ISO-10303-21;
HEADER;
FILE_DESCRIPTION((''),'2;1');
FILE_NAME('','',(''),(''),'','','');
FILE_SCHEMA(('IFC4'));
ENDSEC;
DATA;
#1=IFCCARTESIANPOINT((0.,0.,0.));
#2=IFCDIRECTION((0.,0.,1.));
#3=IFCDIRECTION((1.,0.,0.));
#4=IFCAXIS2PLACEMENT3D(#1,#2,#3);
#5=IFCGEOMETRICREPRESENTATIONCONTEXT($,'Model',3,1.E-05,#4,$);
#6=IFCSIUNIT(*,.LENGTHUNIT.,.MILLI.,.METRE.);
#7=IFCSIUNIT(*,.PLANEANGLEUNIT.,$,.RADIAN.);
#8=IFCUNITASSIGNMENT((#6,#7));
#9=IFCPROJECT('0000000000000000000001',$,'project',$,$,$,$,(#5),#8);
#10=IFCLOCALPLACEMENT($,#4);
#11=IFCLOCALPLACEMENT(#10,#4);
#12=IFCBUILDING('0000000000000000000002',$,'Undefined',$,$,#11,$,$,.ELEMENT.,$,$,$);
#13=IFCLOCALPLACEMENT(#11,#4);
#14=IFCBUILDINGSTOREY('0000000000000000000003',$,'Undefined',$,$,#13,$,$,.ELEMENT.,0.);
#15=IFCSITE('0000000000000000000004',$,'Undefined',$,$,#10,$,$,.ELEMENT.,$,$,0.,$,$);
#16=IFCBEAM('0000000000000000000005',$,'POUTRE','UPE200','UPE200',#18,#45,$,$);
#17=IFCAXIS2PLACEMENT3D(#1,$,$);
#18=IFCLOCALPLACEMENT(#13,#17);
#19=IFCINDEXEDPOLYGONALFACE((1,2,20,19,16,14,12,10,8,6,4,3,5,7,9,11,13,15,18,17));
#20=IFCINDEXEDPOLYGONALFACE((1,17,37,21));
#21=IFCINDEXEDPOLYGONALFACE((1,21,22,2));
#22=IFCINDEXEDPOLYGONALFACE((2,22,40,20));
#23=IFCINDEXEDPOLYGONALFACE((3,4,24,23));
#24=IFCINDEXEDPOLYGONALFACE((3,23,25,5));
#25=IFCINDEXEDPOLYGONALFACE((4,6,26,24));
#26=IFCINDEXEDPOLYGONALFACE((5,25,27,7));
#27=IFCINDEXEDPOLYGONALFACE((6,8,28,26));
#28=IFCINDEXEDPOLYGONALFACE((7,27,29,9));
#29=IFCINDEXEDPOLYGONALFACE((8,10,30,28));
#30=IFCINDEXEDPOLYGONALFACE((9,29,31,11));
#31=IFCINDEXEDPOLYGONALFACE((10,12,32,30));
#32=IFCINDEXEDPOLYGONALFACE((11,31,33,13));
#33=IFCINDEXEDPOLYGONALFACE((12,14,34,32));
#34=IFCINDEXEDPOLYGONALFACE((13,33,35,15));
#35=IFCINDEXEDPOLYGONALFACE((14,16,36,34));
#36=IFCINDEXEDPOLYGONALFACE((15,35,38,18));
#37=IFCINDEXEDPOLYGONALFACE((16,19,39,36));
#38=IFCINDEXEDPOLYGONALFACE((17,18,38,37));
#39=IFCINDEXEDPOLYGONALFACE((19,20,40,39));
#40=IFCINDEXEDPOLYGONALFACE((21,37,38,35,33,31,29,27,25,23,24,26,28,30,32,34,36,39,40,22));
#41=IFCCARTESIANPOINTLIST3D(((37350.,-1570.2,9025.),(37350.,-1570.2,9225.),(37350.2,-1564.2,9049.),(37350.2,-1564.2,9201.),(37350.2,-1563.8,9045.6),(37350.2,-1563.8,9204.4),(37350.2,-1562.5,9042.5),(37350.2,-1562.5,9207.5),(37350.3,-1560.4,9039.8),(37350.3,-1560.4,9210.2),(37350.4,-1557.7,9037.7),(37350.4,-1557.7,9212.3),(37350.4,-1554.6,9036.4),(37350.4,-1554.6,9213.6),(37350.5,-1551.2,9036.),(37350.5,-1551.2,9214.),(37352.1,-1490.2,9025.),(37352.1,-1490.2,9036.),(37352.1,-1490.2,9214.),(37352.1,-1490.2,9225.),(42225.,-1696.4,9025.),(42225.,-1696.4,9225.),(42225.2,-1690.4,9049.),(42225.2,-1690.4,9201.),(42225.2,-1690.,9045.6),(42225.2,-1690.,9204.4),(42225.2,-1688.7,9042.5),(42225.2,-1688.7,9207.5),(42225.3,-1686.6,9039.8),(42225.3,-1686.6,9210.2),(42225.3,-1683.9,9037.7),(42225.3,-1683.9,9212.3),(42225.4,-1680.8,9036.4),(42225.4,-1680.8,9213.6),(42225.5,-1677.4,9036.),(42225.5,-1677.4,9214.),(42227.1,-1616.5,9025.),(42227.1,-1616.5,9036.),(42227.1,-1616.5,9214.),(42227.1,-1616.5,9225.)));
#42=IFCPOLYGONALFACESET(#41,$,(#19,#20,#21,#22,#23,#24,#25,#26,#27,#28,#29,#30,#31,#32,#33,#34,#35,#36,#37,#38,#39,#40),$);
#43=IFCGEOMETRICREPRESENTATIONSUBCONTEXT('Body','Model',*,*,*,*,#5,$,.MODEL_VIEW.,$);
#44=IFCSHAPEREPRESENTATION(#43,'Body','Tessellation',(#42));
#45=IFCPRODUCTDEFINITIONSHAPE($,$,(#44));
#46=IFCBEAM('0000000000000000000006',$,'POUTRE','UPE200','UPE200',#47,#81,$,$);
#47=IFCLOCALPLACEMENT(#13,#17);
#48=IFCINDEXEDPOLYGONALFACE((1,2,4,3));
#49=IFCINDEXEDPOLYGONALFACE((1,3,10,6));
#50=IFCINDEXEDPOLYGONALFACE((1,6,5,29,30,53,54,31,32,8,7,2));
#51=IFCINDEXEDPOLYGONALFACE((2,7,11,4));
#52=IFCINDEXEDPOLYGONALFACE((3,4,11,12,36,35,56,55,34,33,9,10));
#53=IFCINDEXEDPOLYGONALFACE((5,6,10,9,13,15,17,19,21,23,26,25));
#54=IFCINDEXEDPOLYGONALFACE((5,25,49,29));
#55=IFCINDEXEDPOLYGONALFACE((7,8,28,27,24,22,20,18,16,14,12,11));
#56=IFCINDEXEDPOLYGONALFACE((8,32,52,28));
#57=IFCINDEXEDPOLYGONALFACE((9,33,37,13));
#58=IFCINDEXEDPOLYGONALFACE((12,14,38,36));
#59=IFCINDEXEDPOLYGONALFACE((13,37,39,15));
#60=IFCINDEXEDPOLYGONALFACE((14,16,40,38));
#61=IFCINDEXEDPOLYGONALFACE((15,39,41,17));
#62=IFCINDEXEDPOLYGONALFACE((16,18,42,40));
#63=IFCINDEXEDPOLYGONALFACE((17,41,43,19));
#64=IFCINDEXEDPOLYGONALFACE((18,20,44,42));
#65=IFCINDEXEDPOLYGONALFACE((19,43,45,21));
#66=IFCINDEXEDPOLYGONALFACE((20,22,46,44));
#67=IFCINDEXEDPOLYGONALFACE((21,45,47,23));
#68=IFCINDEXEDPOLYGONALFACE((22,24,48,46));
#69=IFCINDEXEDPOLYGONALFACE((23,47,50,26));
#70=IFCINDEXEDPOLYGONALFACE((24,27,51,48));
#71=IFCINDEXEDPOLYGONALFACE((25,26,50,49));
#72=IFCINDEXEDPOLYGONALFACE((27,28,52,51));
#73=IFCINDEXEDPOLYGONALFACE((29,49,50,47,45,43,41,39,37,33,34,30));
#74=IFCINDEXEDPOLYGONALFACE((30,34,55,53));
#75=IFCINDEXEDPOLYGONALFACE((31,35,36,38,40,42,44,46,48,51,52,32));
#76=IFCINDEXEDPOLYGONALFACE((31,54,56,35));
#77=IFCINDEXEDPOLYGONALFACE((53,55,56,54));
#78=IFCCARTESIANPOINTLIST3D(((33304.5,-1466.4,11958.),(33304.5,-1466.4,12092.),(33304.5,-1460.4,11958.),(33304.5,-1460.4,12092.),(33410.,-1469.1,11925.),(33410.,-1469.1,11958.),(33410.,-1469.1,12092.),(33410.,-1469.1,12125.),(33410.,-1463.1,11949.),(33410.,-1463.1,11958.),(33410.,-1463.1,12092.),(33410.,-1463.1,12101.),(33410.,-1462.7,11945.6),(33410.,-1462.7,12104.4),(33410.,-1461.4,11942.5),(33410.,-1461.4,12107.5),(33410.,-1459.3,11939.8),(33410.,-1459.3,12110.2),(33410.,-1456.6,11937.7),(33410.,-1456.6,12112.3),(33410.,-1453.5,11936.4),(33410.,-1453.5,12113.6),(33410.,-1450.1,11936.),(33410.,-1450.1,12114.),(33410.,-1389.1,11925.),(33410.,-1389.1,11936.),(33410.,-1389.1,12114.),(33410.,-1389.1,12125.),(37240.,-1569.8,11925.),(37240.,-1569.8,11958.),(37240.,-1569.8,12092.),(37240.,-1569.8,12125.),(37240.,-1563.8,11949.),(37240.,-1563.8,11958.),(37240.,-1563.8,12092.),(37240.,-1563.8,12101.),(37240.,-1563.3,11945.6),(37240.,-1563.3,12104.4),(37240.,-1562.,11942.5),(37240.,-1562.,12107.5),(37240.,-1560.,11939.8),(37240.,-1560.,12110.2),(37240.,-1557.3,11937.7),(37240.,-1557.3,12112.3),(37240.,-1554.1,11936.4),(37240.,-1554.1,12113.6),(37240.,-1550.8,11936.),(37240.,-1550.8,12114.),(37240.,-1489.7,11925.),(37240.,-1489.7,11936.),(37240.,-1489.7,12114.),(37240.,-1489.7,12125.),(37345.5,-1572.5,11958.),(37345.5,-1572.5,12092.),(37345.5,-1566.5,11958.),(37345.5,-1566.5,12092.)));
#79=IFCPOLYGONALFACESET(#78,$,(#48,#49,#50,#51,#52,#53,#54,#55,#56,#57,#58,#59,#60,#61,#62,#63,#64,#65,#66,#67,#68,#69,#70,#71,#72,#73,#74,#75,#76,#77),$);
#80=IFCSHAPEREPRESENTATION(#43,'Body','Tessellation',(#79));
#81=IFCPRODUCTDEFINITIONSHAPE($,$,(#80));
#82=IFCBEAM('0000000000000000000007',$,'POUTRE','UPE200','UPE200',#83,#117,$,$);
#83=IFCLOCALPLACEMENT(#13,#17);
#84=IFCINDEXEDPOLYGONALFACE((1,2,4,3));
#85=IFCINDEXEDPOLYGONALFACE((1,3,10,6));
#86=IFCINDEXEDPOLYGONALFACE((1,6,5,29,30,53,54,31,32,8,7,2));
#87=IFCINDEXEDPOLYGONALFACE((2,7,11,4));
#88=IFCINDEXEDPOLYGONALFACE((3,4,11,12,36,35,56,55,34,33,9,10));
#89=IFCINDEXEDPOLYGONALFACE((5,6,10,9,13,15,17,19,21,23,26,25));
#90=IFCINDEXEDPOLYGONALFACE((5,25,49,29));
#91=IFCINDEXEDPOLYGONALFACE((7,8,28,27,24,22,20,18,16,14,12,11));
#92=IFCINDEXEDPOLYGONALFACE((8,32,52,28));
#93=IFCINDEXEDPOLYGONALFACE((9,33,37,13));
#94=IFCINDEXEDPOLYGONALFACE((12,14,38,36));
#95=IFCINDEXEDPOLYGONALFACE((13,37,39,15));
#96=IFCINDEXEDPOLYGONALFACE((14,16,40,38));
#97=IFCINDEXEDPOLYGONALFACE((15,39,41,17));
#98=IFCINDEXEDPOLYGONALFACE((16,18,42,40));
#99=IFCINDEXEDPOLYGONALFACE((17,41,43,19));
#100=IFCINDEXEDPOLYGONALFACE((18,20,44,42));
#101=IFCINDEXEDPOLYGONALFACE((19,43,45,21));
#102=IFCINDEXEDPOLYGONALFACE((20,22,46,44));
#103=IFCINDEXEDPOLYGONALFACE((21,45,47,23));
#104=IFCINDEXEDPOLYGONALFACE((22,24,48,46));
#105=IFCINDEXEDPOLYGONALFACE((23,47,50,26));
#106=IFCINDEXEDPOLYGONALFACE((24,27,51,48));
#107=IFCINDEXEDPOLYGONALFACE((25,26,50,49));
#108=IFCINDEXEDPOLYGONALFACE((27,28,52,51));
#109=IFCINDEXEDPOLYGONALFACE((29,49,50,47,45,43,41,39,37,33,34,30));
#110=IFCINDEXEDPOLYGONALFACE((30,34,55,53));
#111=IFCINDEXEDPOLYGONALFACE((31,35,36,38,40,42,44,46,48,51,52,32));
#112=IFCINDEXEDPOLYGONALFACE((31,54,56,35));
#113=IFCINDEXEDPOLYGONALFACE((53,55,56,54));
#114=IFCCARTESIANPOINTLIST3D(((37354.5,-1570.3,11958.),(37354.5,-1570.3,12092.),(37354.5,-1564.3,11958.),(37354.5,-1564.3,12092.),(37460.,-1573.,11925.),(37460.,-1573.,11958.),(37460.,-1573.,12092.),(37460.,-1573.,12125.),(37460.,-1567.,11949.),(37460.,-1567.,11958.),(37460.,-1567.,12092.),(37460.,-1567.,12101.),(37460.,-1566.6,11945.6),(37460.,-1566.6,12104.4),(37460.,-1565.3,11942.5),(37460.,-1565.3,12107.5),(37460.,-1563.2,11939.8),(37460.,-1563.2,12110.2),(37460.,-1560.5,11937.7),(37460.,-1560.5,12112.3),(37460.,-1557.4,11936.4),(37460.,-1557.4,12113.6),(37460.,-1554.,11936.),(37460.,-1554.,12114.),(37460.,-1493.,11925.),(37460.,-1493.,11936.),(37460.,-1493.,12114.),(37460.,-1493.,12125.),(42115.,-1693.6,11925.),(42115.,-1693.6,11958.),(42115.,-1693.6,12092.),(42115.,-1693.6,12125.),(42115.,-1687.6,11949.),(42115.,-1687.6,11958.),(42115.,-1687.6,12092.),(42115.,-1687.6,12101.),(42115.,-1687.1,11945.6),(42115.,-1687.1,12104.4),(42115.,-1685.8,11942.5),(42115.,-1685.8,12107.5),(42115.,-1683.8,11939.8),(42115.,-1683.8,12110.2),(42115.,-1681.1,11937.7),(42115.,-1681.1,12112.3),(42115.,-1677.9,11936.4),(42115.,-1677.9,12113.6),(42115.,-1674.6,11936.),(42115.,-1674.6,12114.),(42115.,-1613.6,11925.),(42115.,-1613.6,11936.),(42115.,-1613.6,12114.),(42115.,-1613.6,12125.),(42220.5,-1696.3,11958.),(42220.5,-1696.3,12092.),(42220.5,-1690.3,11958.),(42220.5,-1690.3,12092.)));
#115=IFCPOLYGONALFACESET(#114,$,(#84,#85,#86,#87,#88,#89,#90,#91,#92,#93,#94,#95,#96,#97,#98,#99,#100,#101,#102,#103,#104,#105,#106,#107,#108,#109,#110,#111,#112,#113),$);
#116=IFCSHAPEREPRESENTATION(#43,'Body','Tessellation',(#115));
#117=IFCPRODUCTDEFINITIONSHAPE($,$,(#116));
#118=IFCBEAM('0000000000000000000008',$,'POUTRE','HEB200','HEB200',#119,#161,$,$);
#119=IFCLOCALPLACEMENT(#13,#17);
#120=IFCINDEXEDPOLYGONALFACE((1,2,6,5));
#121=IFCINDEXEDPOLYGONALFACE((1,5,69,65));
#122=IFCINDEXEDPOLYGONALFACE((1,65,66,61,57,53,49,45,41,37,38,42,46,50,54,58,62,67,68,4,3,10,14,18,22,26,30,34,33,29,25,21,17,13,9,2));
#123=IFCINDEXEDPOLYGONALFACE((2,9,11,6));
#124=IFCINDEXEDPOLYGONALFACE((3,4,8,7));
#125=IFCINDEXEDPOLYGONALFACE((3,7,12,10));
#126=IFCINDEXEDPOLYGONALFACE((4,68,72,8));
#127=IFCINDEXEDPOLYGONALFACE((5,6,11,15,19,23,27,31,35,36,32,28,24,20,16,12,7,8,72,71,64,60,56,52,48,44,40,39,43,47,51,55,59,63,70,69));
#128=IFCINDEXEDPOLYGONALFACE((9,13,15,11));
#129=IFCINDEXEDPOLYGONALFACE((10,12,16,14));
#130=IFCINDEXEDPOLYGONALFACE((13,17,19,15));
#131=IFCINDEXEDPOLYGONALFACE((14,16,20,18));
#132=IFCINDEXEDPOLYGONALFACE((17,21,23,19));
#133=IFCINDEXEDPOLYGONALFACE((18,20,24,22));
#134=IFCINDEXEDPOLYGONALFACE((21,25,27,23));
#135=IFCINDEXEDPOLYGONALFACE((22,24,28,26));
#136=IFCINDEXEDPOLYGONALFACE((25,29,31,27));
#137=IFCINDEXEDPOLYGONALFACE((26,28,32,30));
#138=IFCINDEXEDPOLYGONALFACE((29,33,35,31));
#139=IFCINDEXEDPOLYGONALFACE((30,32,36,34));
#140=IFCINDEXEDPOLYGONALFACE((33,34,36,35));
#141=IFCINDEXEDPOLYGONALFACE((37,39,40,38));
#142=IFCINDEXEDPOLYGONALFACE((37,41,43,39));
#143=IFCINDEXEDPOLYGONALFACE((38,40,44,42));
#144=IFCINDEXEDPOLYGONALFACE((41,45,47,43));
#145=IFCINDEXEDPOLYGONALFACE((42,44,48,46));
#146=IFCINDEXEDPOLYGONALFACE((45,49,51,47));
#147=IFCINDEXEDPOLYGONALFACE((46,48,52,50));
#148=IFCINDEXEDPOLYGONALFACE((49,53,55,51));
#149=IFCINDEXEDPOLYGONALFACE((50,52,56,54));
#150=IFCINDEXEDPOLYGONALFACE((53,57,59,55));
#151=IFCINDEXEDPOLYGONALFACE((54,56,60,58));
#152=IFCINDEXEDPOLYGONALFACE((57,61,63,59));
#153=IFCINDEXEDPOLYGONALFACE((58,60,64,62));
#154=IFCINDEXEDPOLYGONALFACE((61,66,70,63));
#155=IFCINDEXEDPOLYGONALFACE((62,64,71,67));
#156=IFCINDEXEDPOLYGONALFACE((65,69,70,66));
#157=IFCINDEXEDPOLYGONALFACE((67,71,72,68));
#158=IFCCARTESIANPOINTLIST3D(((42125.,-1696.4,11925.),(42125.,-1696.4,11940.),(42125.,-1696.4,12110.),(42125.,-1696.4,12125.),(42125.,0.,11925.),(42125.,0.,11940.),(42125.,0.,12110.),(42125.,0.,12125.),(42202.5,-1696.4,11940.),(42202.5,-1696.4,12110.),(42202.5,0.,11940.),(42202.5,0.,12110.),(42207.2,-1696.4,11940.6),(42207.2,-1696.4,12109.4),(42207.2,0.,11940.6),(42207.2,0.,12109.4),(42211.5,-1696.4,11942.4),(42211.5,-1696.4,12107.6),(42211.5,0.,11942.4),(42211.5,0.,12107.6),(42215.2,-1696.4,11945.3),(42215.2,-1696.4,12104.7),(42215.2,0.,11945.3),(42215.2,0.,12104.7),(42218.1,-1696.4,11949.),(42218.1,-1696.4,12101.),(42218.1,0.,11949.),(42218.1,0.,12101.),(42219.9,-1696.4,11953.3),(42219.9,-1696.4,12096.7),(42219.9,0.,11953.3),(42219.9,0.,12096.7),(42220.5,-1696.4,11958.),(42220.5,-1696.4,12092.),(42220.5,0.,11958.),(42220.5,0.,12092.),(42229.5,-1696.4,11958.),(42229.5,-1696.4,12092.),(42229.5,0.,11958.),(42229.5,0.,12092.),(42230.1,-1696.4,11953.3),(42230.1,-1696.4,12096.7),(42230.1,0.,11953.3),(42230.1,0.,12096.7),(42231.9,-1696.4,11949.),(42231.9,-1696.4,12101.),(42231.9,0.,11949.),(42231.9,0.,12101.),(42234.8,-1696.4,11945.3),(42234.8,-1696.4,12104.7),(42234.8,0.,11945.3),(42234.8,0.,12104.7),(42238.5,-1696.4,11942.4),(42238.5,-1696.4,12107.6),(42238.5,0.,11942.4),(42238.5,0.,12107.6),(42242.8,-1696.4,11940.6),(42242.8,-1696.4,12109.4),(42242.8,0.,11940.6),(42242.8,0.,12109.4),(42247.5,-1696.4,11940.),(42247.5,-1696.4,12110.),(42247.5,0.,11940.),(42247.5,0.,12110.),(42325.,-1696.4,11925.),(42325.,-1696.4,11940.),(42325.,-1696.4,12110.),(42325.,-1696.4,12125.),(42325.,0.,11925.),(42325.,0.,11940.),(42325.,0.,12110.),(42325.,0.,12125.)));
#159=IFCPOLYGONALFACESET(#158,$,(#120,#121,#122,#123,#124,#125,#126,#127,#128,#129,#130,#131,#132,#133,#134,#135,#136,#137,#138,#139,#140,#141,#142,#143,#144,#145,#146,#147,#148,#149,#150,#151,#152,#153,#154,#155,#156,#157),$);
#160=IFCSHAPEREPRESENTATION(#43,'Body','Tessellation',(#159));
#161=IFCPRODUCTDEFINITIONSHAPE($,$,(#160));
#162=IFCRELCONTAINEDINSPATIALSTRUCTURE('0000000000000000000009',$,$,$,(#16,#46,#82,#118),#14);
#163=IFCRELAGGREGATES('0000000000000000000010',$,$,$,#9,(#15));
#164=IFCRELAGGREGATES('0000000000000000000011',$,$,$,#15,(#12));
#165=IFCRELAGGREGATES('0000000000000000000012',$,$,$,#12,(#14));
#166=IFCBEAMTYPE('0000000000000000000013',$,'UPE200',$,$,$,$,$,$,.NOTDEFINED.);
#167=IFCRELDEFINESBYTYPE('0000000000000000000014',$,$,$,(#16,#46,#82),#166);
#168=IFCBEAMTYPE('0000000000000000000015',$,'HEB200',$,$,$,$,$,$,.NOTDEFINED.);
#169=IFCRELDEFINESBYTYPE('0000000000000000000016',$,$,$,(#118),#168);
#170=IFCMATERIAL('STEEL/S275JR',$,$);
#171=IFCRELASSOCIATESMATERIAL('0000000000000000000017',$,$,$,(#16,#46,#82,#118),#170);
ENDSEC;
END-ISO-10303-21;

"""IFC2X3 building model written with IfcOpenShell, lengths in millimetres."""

from ifc_helpers import new_model, si_unit, frame, origin_with_axes, origin_2d_with_axis, place, context, subcontext, project, spatial, rectangle, i_section, u_section, extrude, boolean, halfspace, material, type_object, element, save


model = new_model("IFC2X3")

# Units and contexts
model_context = context("Model", 3, precision=1e-05, world=origin_with_axes())
body_context = subcontext(model_context, "Body", "Model", "MODEL_VIEW")
ifc_project = project(units=[si_unit("LENGTHUNIT", "METRE", prefix="MILLI"), si_unit("PLANEANGLEUNIT", "RADIAN")], contexts=[model_context])

# Site, building, storey
site_placement = place(None, origin_with_axes())
site = spatial("IfcSite", under=ifc_project, at=site_placement, Name="Undefined", CompositionType="ELEMENT", RefElevation=0.0)
building_placement = place(site_placement, origin_with_axes())
building = spatial("IfcBuilding", under=site, at=building_placement, Name="Undefined", CompositionType="ELEMENT")
storey_placement = place(building_placement, origin_with_axes())
storey = spatial("IfcBuildingStorey", under=building, at=storey_placement, Name="Undefined", CompositionType="ELEMENT", Elevation=0.0)

# Shared definitions
ifc_material_1 = material(Name="STEEL/S275JR")

# Beams
beam_type_1 = type_object("IfcBeamType", Name="UPE200", PredefinedType="NOTDEFINED")
for number, where, z_axis, x_axis, name in (
    (1, (37351.0, -1530.2, 9125.0), (0.0, 0.0, -1.0), (0.999665, -0.025886, 0.0), "POUTRE"),
):
    element("IfcBeam", number, at=place(storey_placement, frame(where, z_axis=z_axis, x_axis=x_axis)), inside=storey, type_object=beam_type_1, material=ifc_material_1, Name=name, Description="UPE200", ObjectType="UPE200", context=body_context, shape_type="SweptSolid", body=[
        extrude(u_section(Depth=200.0, FlangeWidth=80.0, WebThickness=6.0, FlangeThickness=11.0, FilletRadius=13.0, at=origin_2d_with_axis()), frame((4876.6, 0.0, 0.0), z_axis=(-1.0, 0.0, 0.0), x_axis=(0.0, -1.0, 0.0)), (0.0, 0.0, 1.0), 4876.6),
    ])
beam_1_placement = place(storey_placement, frame((33301.1, -1426.3, 12025.0), z_axis=(0.0, 0.0, -1.0), x_axis=(0.999655, -0.026267, 0.0)))
element("IfcBeam", 2, at=beam_1_placement, inside=storey, type_object=beam_type_1, material=ifc_material_1, Name="POUTRE", Description="UPE200", ObjectType="UPE200", context=body_context, shape_type="CSG", body=[
    boolean("DIFFERENCE", boolean("DIFFERENCE", boolean("DIFFERENCE", boolean("DIFFERENCE", boolean("DIFFERENCE", boolean("DIFFERENCE", extrude(u_section(Depth=200.0, FlangeWidth=80.0, WebThickness=6.0, FlangeThickness=11.0, FilletRadius=13.0, at=origin_2d_with_axis()), frame((4047.9, 0.0, 0.0), z_axis=(-1.0, 0.0, 0.0), x_axis=(0.0, -1.0, 0.0)), (0.0, 0.0, 1.0), 4046.5), extrude(rectangle(XDim=34.0, YDim=107.5, at=origin_2d_with_axis()), frame((3990.3, -143.0, 84.0), z_axis=(0.026267, 0.999655, 0.0), x_axis=(0.0, 0.0, 1.0)), (0.0, 0.0, 1.0), 185.4)), extrude(rectangle(XDim=34.0, YDim=107.5, at=origin_2d_with_axis()), frame((3990.3, -143.0, -84.0), z_axis=(0.026267, 0.999655, 0.0), x_axis=(0.0, 0.0, 1.0)), (0.0, 0.0, 1.0), 185.4)), extrude(rectangle(XDim=34.0, YDim=107.5, at=origin_2d_with_axis()), frame((59.0, 145.8, 84.0), z_axis=(-0.026267, -0.999655, 0.0), x_axis=(0.0, 0.0, 1.0)), (0.0, 0.0, 1.0), 188.2)), extrude(rectangle(XDim=34.0, YDim=107.5, at=origin_2d_with_axis()), frame((59.0, 145.8, -84.0), z_axis=(-0.026267, -0.999655, 0.0), x_axis=(0.0, 0.0, 1.0)), (0.0, 0.0, 1.0), 188.2)), halfspace(frame((4045.8, 0.0, 1000.0), z_axis=(-0.999655, 0.026267, 0.0), x_axis=(-0.026267, -0.999655, 0.0)), True)), halfspace(frame((3.5, 0.0, 1000.0), z_axis=(0.999655, -0.026267, 0.0), x_axis=(0.026267, 0.999655, 0.0)), True)),
])
beam_2_placement = place(storey_placement, frame((37351.0, -1530.2, 12025.0), z_axis=(0.0, 0.0, -1.0), x_axis=(0.999665, -0.025886, 0.0)))
element("IfcBeam", 3, at=beam_2_placement, inside=storey, type_object=beam_type_1, material=ifc_material_1, Name="POUTRE", Description="UPE200", ObjectType="UPE200", context=body_context, shape_type="CSG", body=[
    boolean("DIFFERENCE", boolean("DIFFERENCE", boolean("DIFFERENCE", boolean("DIFFERENCE", boolean("DIFFERENCE", boolean("DIFFERENCE", extrude(u_section(Depth=200.0, FlangeWidth=80.0, WebThickness=6.0, FlangeThickness=11.0, FilletRadius=13.0, at=origin_2d_with_axis()), frame((4873.1, 0.0, 0.0), z_axis=(-1.0, 0.0, 0.0), x_axis=(0.0, -1.0, 0.0)), (0.0, 0.0, 1.0), 4871.7), extrude(rectangle(XDim=34.0, YDim=107.5, at=origin_2d_with_axis()), frame((4815.1, -162.9, 84.0), z_axis=(0.025886, 0.999665, 0.0), x_axis=(0.0, 0.0, 1.0)), (0.0, 0.0, 1.0), 205.3)), extrude(rectangle(XDim=34.0, YDim=107.5, at=origin_2d_with_axis()), frame((4815.1, -162.9, -84.0), z_axis=(0.025886, 0.999665, 0.0), x_axis=(0.0, 0.0, 1.0)), (0.0, 0.0, 1.0), 205.3)), extrude(rectangle(XDim=34.0, YDim=107.5, at=origin_2d_with_axis()), frame((59.5, 165.6, 84.0), z_axis=(-0.025886, -0.999665, 0.0), x_axis=(0.0, 0.0, 1.0)), (0.0, 0.0, 1.0), 208.0)), extrude(rectangle(XDim=34.0, YDim=107.5, at=origin_2d_with_axis()), frame((59.5, 165.6, -84.0), z_axis=(-0.025886, -0.999665, 0.0), x_axis=(0.0, 0.0, 1.0)), (0.0, 0.0, 1.0), 208.0)), halfspace(frame((4871.1, 0.0, 1000.0), z_axis=(-0.999665, 0.025886, 0.0), x_axis=(-0.025886, -0.999665, 0.0)), True)), halfspace(frame((3.5, 0.0, 1000.0), z_axis=(0.999665, -0.025886, 0.0), x_axis=(0.025886, 0.999665, 0.0)), True)),
])
beam_type_2 = type_object("IfcBeamType", Name="HEB200", PredefinedType="NOTDEFINED")
beam_3_placement = place(storey_placement, frame((42225.0, 0.0, 12025.0), z_axis=(0.0, 0.0, 1.0), x_axis=(0.0, -1.0, 0.0)))
element("IfcBeam", 4, at=beam_3_placement, inside=storey, type_object=beam_type_2, material=ifc_material_1, Name="POUTRE", Description="HEB200", ObjectType="HEB200", context=body_context, shape_type="SweptSolid", body=[
    extrude(i_section(OverallWidth=200.0, OverallDepth=200.0, WebThickness=9.0, FlangeThickness=15.0, FilletRadius=18.0, at=origin_2d_with_axis()), frame((1696.4, 0.0, 0.0), z_axis=(-1.0, 0.0, 0.0), x_axis=(0.0, -1.0, 0.0)), (0.0, 0.0, 1.0), 1696.4),
])

save(model, "model.ifc")
